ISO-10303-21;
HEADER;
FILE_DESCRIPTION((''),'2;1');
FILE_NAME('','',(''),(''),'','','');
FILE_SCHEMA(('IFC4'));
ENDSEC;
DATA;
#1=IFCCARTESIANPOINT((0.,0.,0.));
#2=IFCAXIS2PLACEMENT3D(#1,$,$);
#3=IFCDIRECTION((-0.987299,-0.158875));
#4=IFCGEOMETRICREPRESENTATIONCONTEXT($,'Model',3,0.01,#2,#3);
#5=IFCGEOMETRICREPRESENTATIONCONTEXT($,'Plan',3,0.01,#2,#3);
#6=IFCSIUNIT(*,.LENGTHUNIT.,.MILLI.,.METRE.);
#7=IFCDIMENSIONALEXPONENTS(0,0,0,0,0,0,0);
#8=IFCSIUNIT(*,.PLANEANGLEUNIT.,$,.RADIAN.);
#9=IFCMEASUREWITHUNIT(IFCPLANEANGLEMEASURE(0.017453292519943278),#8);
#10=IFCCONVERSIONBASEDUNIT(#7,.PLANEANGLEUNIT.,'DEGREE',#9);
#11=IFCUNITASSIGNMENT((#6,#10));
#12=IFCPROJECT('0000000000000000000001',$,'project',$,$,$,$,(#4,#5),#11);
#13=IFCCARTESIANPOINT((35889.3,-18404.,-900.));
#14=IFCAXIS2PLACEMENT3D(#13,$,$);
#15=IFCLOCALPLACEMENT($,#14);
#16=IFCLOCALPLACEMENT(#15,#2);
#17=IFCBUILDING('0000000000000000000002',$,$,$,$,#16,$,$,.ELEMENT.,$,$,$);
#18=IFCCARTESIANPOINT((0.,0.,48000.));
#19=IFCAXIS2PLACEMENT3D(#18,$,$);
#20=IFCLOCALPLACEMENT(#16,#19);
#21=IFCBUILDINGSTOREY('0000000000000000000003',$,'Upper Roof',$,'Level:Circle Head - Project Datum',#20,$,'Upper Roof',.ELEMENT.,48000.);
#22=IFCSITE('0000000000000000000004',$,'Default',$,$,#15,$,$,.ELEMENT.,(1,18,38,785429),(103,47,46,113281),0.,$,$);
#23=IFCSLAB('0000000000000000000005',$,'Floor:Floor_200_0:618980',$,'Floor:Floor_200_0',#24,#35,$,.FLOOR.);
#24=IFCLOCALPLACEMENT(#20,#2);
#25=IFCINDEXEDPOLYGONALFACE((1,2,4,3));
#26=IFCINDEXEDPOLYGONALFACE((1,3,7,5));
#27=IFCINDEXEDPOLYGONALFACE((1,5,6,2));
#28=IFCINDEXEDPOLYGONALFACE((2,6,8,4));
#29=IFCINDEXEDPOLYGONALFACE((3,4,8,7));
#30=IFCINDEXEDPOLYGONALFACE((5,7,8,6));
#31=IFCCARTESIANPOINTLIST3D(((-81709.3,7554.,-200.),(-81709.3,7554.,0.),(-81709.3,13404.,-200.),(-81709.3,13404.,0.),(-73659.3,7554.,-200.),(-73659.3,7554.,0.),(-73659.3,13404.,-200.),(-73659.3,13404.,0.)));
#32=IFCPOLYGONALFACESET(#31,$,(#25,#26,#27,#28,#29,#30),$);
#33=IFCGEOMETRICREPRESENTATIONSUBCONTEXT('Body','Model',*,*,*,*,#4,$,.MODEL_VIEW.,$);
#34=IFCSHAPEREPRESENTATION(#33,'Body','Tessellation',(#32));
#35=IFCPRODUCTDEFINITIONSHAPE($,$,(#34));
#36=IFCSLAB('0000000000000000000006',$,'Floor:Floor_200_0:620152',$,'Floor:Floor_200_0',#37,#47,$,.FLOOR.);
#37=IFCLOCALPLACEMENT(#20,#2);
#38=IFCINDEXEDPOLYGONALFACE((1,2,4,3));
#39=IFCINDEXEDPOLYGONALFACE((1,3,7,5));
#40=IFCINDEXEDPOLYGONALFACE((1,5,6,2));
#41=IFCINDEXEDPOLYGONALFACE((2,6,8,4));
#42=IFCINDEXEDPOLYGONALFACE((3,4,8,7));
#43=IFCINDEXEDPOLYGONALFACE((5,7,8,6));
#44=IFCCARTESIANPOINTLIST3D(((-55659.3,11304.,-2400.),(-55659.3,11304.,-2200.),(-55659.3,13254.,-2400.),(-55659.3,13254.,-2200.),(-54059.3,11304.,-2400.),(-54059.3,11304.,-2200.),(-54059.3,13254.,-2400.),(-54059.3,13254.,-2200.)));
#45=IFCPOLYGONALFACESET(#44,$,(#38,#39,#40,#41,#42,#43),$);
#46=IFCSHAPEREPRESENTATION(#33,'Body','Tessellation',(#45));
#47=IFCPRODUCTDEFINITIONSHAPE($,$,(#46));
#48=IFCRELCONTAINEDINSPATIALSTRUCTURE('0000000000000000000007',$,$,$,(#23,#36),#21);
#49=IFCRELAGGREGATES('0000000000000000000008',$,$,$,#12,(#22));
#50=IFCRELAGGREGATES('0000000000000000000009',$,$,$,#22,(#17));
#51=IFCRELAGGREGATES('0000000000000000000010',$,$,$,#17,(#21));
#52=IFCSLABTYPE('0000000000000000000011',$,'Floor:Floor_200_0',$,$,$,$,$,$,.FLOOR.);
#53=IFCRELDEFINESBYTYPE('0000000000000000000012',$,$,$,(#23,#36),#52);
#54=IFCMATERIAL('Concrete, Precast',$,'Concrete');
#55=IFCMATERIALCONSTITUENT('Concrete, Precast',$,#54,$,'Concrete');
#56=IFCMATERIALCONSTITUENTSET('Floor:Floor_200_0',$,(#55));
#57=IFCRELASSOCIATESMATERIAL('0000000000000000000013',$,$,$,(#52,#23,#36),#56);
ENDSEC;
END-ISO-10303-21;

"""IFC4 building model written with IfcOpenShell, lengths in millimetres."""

from ifc_helpers import new_model, entity, si_unit, converted_unit, direction, frame, origin, place, context, subcontext, project, spatial, indexed_curve, outline, extrude, material, constituent, constituent_set, type_object, element, save


model = new_model("IFC4")

# Units and contexts
model_context = context("Model", 3, precision=0.01, world=origin(), true_north=direction((-0.987299, -0.158875)))
plan_context = context("Plan", 3, precision=0.01, world=origin(), true_north=direction((-0.987299, -0.158875)))
body_context = subcontext(model_context, "Body", "Model", "MODEL_VIEW")
ifc_project = project(units=[si_unit("LENGTHUNIT", "METRE", prefix="MILLI"), converted_unit("PLANEANGLEUNIT", "DEGREE", entity("IfcPlaneAngleMeasure", 0.017453292519943278), si_unit("PLANEANGLEUNIT", "RADIAN"), dimensions=[0, 0, 0, 0, 0, 0, 0])], contexts=[model_context, plan_context])

# Site, building, storey
site_placement = place(None, frame((35889.3, -18404.0, -900.0)))
site = spatial("IfcSite", under=ifc_project, at=site_placement, Name="Default", CompositionType="ELEMENT", RefLatitude=(1, 18, 38, 785429), RefLongitude=(103, 47, 46, 113281), RefElevation=0.0)
building_placement = place(site_placement, origin())
building = spatial("IfcBuilding", under=site, at=building_placement, CompositionType="ELEMENT")
storey_placement = place(building_placement, frame((0.0, 0.0, 48000.0)))
storey = spatial("IfcBuildingStorey", under=building, at=storey_placement, Name="Upper Roof", ObjectType="Level:Circle Head - Project Datum", LongName="Upper Roof", CompositionType="ELEMENT", Elevation=48000.0)

# Slabs
ifc_material = material(Name="Concrete, Precast", Category="Concrete")
ifc_constituent = constituent(ifc_material, Name="Concrete, Precast", Category="Concrete")
ifc_constituent_set = constituent_set(constituents=[ifc_constituent], Name="Floor:Floor_200_0")
slab_type = type_object("IfcSlabType", Name="Floor:Floor_200_0", PredefinedType="FLOOR", material=ifc_constituent_set)
slab_1_placement = place(storey_placement, origin())
element("IfcSlab", 1, at=slab_1_placement, inside=storey, type_object=slab_type, material=ifc_constituent_set, Name="Floor:Floor_200_0:618980", ObjectType="Floor:Floor_200_0", PredefinedType="FLOOR", context=body_context, shape_type="SweptSolid", body=[
    extrude(outline(indexed_curve([(-2925.0, -4025.0), (2925.0, -4025.0), (2925.0, 4025.0), (-2925.0, 4025.0), (-2925.0, -4025.0)], self_intersect=False)), frame((-77684.3, 10479.0, 0.0), z_axis=(0.0, 0.0, -1.0), x_axis=(0.0, 1.0, 0.0)), (0.0, 0.0, 1.0), 200.0),
])
slab_2_placement = place(storey_placement, origin())
element("IfcSlab", 2, at=slab_2_placement, inside=storey, type_object=slab_type, material=ifc_constituent_set, Name="Floor:Floor_200_0:620152", ObjectType="Floor:Floor_200_0", PredefinedType="FLOOR", context=body_context, shape_type="SweptSolid", body=[
    extrude(outline(indexed_curve([(-975.0, -800.0), (975.0, -800.0), (975.0, 800.0), (-975.0, 800.0), (-975.0, -800.0)], self_intersect=False)), frame((-54859.3, 12279.0, -2200.0), z_axis=(0.0, 0.0, -1.0), x_axis=(0.0, 1.0, 0.0)), (0.0, 0.0, 1.0), 200.0),
])

save(model, "model.ifc")
